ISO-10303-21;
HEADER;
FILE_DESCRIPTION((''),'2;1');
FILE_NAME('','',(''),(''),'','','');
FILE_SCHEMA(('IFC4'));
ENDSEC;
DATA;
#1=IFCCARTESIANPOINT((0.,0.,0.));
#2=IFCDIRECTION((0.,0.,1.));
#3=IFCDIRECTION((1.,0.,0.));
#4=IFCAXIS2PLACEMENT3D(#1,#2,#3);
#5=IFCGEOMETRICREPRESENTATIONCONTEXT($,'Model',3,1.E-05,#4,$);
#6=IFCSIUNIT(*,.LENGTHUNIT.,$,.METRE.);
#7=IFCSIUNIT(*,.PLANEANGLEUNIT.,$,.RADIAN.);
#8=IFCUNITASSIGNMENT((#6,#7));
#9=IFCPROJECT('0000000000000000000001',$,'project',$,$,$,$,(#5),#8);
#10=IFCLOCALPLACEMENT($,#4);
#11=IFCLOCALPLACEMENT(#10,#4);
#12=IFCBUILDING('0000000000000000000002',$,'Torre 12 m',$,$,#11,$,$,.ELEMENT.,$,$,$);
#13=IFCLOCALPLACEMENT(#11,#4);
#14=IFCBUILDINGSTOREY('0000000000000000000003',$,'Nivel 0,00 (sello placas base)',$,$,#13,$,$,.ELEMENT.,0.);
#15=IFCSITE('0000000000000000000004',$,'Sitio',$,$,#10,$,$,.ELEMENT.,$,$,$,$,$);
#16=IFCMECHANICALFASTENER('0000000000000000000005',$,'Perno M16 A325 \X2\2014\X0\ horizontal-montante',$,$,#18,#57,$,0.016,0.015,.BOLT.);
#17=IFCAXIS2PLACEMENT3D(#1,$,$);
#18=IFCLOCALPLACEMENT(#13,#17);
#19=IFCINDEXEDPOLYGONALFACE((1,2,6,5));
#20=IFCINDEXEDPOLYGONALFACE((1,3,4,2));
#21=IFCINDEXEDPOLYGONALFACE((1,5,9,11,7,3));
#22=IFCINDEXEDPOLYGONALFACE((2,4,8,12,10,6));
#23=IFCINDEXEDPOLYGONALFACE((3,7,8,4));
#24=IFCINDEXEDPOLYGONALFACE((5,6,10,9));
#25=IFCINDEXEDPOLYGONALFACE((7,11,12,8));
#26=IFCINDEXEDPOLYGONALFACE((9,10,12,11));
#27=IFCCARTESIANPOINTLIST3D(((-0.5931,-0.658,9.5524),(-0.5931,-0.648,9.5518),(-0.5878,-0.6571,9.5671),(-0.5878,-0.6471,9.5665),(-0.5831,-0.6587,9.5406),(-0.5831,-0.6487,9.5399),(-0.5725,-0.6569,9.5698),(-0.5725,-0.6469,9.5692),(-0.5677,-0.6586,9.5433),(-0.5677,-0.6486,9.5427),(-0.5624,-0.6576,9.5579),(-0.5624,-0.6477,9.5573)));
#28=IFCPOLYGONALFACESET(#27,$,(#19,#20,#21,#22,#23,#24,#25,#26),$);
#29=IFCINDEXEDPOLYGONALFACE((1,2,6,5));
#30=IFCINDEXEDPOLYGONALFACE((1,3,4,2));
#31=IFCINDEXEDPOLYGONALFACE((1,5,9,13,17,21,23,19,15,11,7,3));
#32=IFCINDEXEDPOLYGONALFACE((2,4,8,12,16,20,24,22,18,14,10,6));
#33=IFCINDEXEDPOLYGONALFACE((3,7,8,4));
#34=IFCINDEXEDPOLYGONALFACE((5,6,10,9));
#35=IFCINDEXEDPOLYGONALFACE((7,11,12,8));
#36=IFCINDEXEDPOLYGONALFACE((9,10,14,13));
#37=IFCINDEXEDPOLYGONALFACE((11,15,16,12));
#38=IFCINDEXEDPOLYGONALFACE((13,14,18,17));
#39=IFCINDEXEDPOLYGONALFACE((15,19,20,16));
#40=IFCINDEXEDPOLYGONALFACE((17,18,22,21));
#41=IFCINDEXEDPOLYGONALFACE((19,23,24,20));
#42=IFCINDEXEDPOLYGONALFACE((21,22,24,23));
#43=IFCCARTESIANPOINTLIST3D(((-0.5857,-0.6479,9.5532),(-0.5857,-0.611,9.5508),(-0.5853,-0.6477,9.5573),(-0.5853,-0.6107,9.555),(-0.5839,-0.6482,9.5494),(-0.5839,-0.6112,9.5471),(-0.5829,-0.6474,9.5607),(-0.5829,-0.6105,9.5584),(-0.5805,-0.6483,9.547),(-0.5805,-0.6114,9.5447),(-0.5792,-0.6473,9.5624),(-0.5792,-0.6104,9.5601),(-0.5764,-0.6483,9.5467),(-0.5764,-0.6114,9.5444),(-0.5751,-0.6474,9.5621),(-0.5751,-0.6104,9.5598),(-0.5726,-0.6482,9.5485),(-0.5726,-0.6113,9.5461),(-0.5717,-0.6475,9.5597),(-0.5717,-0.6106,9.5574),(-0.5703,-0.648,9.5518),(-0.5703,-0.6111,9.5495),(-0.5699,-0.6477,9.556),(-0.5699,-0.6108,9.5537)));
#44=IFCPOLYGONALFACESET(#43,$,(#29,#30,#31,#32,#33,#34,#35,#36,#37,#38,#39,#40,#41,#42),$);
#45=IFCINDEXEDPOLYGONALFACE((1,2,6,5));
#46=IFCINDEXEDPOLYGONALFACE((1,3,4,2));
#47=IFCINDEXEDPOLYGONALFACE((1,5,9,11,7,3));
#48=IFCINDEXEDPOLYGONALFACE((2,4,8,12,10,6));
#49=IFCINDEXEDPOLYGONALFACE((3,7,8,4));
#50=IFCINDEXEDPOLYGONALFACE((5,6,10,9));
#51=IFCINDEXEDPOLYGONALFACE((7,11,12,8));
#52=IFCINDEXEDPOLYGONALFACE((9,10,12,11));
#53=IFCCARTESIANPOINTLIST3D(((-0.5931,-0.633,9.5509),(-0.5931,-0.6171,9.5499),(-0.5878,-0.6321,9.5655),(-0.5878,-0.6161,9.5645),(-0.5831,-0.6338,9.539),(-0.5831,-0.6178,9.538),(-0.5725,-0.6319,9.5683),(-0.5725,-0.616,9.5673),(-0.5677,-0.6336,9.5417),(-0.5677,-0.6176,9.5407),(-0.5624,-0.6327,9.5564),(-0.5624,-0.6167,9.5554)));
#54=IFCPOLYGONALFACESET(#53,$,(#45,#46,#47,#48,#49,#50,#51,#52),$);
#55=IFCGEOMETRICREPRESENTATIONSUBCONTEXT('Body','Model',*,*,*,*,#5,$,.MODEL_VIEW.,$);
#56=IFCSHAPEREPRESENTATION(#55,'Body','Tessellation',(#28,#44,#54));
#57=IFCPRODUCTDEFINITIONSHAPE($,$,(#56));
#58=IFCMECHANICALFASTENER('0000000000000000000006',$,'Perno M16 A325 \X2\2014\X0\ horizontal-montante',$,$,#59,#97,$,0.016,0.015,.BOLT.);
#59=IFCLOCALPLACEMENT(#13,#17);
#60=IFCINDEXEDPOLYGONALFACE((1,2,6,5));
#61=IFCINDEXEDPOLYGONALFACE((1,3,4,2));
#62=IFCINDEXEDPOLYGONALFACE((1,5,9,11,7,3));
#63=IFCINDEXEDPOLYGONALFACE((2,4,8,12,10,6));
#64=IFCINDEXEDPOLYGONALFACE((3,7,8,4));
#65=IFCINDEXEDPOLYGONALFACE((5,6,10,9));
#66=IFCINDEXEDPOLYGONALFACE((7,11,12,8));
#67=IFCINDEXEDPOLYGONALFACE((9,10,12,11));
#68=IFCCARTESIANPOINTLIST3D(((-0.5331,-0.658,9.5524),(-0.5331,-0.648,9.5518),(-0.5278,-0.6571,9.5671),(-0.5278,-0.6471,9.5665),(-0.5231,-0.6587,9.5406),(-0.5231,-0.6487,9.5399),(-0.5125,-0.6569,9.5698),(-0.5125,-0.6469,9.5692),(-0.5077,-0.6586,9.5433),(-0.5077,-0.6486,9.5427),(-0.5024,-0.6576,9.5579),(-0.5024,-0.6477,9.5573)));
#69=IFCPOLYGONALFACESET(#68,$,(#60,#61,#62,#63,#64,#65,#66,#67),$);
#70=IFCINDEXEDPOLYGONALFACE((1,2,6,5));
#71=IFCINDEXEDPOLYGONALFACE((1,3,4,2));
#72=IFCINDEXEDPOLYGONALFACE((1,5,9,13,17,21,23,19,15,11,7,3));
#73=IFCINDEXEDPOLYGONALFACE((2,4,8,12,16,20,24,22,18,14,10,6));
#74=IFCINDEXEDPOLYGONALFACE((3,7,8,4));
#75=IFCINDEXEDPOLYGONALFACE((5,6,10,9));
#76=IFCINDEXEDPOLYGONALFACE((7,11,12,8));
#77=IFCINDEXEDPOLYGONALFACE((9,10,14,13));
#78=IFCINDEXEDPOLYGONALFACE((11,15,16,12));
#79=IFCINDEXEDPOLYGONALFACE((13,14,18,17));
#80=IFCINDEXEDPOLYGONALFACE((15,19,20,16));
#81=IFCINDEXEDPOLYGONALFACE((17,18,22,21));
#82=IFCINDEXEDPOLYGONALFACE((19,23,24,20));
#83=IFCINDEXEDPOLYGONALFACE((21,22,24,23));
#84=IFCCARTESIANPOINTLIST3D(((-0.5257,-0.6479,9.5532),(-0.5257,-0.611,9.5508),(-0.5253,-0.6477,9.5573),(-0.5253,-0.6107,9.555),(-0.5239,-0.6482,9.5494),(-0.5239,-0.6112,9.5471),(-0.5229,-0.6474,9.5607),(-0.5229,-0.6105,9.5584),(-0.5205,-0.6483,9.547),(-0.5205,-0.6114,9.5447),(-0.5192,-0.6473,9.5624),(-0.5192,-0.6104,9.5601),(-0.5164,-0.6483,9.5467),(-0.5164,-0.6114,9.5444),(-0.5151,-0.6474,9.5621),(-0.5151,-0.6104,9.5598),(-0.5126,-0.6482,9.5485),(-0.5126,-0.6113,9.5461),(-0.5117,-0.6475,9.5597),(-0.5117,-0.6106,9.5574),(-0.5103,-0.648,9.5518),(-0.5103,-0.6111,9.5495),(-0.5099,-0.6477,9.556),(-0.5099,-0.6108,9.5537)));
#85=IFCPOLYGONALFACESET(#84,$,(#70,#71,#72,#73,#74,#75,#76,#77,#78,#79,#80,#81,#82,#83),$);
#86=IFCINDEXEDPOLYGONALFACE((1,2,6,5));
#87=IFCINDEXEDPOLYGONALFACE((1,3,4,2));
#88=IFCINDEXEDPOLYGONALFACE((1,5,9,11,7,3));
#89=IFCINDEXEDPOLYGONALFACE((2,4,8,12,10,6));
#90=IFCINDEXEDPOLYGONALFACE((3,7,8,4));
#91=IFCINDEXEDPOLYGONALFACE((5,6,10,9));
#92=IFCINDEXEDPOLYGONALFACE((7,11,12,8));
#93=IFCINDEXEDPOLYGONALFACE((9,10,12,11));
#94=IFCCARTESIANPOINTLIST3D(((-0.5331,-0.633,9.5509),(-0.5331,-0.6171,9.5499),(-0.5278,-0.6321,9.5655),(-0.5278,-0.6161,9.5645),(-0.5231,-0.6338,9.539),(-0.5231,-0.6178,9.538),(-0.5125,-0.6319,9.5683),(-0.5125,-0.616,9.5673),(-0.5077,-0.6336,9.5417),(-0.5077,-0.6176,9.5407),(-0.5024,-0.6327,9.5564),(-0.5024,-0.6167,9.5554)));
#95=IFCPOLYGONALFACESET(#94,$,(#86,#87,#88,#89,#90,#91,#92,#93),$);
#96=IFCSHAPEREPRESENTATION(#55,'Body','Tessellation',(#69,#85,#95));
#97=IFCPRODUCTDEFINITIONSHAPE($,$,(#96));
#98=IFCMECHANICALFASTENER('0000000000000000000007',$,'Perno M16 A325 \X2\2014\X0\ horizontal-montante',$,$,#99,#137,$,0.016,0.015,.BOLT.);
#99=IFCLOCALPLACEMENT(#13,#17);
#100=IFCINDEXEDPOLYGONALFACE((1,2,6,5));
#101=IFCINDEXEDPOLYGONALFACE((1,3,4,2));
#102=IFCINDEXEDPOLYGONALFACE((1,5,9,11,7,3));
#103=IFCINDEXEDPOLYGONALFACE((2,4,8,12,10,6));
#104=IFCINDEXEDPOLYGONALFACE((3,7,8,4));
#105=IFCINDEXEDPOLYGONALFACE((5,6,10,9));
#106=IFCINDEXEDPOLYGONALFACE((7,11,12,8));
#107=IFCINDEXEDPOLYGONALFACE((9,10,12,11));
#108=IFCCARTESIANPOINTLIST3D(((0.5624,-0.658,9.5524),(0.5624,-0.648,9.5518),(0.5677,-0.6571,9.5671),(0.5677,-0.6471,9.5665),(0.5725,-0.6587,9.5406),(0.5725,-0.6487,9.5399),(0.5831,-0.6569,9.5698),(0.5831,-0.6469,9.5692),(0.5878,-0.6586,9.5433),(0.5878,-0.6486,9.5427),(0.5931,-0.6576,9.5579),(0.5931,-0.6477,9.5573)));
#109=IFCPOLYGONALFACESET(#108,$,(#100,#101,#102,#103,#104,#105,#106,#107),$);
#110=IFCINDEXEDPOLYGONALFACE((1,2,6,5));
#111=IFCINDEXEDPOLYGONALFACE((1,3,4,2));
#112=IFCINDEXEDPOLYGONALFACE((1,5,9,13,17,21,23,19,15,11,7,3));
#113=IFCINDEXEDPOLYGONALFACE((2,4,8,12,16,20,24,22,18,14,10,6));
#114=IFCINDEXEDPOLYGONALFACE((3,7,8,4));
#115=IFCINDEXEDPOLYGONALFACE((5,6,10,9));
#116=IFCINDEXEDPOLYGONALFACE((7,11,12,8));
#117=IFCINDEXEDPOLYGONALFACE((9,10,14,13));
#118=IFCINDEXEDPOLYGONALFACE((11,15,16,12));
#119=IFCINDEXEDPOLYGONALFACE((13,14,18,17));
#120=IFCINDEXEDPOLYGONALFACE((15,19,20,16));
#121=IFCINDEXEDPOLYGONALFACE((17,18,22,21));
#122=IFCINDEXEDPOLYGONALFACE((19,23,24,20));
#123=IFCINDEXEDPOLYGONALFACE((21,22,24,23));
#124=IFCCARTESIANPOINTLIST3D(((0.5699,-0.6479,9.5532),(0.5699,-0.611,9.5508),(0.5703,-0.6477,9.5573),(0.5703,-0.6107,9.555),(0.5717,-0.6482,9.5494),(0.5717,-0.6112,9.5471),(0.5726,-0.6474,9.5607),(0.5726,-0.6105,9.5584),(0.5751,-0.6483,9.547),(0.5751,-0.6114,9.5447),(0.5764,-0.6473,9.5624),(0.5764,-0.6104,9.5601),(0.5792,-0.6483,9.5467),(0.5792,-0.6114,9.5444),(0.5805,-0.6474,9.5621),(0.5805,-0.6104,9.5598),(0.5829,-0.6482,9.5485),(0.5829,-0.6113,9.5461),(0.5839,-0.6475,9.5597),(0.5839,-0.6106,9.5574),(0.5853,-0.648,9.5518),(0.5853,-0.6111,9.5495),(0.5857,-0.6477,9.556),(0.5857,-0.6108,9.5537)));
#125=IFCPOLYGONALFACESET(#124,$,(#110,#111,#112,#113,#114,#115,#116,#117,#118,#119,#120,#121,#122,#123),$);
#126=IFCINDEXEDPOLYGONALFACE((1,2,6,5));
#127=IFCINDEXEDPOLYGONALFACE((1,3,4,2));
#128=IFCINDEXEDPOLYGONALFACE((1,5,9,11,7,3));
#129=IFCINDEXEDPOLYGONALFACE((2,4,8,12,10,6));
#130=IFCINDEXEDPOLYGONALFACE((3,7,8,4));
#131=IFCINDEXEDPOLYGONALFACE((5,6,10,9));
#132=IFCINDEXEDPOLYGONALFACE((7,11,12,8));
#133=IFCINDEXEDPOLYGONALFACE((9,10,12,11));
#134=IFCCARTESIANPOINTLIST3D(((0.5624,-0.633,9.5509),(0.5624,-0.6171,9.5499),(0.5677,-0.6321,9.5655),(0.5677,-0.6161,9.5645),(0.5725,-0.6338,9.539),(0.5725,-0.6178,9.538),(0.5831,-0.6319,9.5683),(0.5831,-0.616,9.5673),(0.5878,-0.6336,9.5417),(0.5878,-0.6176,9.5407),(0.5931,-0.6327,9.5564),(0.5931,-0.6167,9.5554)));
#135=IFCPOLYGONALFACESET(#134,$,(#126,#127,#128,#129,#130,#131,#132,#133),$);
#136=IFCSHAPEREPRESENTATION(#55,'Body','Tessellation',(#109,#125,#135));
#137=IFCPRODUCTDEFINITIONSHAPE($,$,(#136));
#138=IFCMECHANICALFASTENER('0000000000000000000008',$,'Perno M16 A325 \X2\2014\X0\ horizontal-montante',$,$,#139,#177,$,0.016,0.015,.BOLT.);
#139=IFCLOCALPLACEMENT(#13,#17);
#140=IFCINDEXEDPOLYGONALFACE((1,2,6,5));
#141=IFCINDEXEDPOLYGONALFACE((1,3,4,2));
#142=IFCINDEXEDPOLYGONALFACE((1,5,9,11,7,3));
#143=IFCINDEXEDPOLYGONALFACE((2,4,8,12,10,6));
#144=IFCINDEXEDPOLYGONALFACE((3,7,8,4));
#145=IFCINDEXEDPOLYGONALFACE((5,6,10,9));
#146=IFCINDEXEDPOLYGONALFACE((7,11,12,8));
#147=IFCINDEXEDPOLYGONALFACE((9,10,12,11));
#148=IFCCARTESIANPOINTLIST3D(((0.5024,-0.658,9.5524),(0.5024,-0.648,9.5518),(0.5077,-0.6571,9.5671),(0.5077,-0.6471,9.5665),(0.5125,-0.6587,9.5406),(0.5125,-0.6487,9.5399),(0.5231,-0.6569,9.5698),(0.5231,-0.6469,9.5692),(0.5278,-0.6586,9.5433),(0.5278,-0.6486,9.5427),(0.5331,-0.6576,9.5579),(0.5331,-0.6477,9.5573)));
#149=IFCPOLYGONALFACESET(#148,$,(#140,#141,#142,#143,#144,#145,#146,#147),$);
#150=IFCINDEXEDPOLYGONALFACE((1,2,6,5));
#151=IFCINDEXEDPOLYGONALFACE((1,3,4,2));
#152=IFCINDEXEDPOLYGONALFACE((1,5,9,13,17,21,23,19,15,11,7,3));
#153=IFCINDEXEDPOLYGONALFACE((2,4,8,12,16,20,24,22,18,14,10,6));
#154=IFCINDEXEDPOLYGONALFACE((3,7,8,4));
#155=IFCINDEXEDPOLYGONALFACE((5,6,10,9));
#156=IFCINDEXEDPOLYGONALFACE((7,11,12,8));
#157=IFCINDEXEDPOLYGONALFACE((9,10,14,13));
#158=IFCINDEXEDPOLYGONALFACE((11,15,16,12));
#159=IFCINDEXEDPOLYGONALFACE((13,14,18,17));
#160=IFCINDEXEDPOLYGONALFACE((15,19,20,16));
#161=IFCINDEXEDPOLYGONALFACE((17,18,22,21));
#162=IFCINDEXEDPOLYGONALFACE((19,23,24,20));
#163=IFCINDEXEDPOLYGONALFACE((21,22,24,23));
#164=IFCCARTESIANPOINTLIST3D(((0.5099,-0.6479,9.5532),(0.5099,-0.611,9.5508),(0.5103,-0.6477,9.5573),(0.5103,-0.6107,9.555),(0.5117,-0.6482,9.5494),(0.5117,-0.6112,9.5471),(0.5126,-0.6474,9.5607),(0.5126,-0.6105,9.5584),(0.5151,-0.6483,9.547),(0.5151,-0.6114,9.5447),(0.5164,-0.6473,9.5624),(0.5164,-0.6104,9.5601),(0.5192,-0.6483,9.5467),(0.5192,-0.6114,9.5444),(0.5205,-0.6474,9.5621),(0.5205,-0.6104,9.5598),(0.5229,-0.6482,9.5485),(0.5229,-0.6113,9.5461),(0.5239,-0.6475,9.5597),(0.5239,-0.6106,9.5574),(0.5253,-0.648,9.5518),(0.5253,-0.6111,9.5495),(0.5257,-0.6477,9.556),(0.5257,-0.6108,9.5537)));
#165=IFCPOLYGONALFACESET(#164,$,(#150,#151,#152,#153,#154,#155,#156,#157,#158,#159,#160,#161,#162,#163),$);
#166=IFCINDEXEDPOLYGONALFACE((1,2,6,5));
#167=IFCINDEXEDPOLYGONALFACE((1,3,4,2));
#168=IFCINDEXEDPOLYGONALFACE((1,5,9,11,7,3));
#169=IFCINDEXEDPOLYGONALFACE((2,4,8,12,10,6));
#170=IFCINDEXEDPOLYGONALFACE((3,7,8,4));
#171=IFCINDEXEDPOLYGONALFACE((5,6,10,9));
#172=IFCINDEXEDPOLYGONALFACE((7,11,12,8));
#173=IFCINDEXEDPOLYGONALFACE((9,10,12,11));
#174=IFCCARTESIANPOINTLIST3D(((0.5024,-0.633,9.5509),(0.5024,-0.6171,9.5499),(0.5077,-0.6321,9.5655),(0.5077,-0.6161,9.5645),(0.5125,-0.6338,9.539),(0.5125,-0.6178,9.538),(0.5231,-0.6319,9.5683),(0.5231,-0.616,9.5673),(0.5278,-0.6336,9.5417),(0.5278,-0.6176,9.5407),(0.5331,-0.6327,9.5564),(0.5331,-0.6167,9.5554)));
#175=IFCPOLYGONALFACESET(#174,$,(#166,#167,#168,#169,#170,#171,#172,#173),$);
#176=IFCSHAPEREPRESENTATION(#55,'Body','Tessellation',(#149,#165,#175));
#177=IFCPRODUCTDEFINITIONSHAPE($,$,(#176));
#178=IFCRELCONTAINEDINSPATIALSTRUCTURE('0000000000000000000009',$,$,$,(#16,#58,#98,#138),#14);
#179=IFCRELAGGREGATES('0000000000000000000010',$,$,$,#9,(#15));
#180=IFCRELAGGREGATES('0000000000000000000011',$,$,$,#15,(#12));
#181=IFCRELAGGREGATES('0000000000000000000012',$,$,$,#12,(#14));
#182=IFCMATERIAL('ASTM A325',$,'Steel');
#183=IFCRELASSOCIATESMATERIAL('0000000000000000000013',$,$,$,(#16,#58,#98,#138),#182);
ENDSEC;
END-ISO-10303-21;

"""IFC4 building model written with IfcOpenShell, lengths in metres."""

from ifc_helpers import new_model, si_unit, frame, origin_with_axes, place, context, subcontext, project, spatial, polyline, outline, extrude, material, element, save


model = new_model("IFC4")

# Units and contexts
model_context = context("Model", 3, precision=1e-05, world=origin_with_axes())
body_context = subcontext(model_context, "Body", "Model", "MODEL_VIEW")
ifc_project = project(units=[si_unit("LENGTHUNIT", "METRE"), si_unit("PLANEANGLEUNIT", "RADIAN")], contexts=[model_context])

# Site, building, storey
site_placement = place(None, origin_with_axes())
site = spatial("IfcSite", under=ifc_project, at=site_placement, Name="Sitio", CompositionType="ELEMENT")
building_placement = place(site_placement, origin_with_axes())
building = spatial("IfcBuilding", under=site, at=building_placement, Name="Torre 12 m", CompositionType="ELEMENT")
storey_placement = place(building_placement, origin_with_axes())
storey = spatial("IfcBuildingStorey", under=building, at=storey_placement, Name="Nivel 0,00 (sello placas base)", CompositionType="ELEMENT", Elevation=0.0)

# Shared definitions
placement = place(storey_placement, origin_with_axes())

# Mechanical fasteners
ifc_material_1 = material(Name="ASTM A325", Category="Steel")
element("IfcMechanicalFastener", 1, at=placement, inside=storey, material=ifc_material_1, Name="Perno M16 A325 — horizontal-montante", NominalDiameter=0.016, NominalLength=0.015, PredefinedType="BOLT", context=body_context, shape_type="SweptSolid", body=[
    extrude(outline(polyline([(0.0135, 0.0078), (0.0, 0.0156), (-0.0135, 0.0078), (-0.0135, -0.0078), (0.0, -0.0156), (0.0135, -0.0078), (0.0135, 0.0078)])), frame((-0.5778, -0.6578, 9.5552), z_axis=(0.0, 0.998053, -0.062378), x_axis=(0.940405, -0.021212, -0.339394)), (0.0, 0.0, 1.0), 0.01),
    extrude(outline(polyline([(0.008, 0.0), (0.0069, 0.004), (0.004, 0.0069), (0.0, 0.008), (-0.004, 0.0069), (-0.0069, 0.004), (-0.008, 0.0), (-0.0069, -0.004), (-0.004, -0.0069), (0.0, -0.008), (0.004, -0.0069), (0.0069, -0.004), (0.008, 0.0)])), frame((-0.5778, -0.6478, 9.5546), z_axis=(0.0, 0.998053, -0.062378), x_axis=(0.940405, -0.021212, -0.339394)), (0.0, 0.0, 1.0), 0.037),
    extrude(outline(polyline([(0.0135, 0.0078), (0.0, 0.0156), (-0.0135, 0.0078), (-0.0135, -0.0078), (0.0, -0.0156), (0.0135, -0.0078), (0.0135, 0.0078)])), frame((-0.5778, -0.6329, 9.5536), z_axis=(0.0, 0.998053, -0.062378), x_axis=(0.940405, -0.021212, -0.339394)), (0.0, 0.0, 1.0), 0.016),
])
element("IfcMechanicalFastener", 2, at=placement, inside=storey, material=ifc_material_1, Name="Perno M16 A325 — horizontal-montante", NominalDiameter=0.016, NominalLength=0.015, PredefinedType="BOLT", context=body_context, shape_type="SweptSolid", body=[
    extrude(outline(polyline([(0.0135, 0.0078), (0.0, 0.0156), (-0.0135, 0.0078), (-0.0135, -0.0078), (0.0, -0.0156), (0.0135, -0.0078), (0.0135, 0.0078)])), frame((-0.5178, -0.6578, 9.5552), z_axis=(0.0, 0.998053, -0.062378), x_axis=(0.940405, -0.021212, -0.339394)), (0.0, 0.0, 1.0), 0.01),
    extrude(outline(polyline([(0.008, 0.0), (0.0069, 0.004), (0.004, 0.0069), (0.0, 0.008), (-0.004, 0.0069), (-0.0069, 0.004), (-0.008, 0.0), (-0.0069, -0.004), (-0.004, -0.0069), (0.0, -0.008), (0.004, -0.0069), (0.0069, -0.004), (0.008, 0.0)])), frame((-0.5178, -0.6478, 9.5546), z_axis=(0.0, 0.998053, -0.062378), x_axis=(0.940405, -0.021212, -0.339394)), (0.0, 0.0, 1.0), 0.037),
    extrude(outline(polyline([(0.0135, 0.0078), (0.0, 0.0156), (-0.0135, 0.0078), (-0.0135, -0.0078), (0.0, -0.0156), (0.0135, -0.0078), (0.0135, 0.0078)])), frame((-0.5178, -0.6329, 9.5536), z_axis=(0.0, 0.998053, -0.062378), x_axis=(0.940405, -0.021212, -0.339394)), (0.0, 0.0, 1.0), 0.016),
])
element("IfcMechanicalFastener", 3, at=placement, inside=storey, material=ifc_material_1, Name="Perno M16 A325 — horizontal-montante", NominalDiameter=0.016, NominalLength=0.015, PredefinedType="BOLT", context=body_context, shape_type="SweptSolid", body=[
    extrude(outline(polyline([(0.0135, 0.0078), (0.0, 0.0156), (-0.0135, 0.0078), (-0.0135, -0.0078), (0.0, -0.0156), (0.0135, -0.0078), (0.0135, 0.0078)])), frame((0.5778, -0.6578, 9.5552), z_axis=(0.0, 0.998053, -0.062378), x_axis=(0.940405, -0.021212, -0.339394)), (0.0, 0.0, 1.0), 0.01),
    extrude(outline(polyline([(0.008, 0.0), (0.0069, 0.004), (0.004, 0.0069), (0.0, 0.008), (-0.004, 0.0069), (-0.0069, 0.004), (-0.008, 0.0), (-0.0069, -0.004), (-0.004, -0.0069), (0.0, -0.008), (0.004, -0.0069), (0.0069, -0.004), (0.008, 0.0)])), frame((0.5778, -0.6478, 9.5546), z_axis=(0.0, 0.998053, -0.062378), x_axis=(0.940405, -0.021212, -0.339394)), (0.0, 0.0, 1.0), 0.037),
    extrude(outline(polyline([(0.0135, 0.0078), (0.0, 0.0156), (-0.0135, 0.0078), (-0.0135, -0.0078), (0.0, -0.0156), (0.0135, -0.0078), (0.0135, 0.0078)])), frame((0.5778, -0.6329, 9.5536), z_axis=(0.0, 0.998053, -0.062378), x_axis=(0.940405, -0.021212, -0.339394)), (0.0, 0.0, 1.0), 0.016),
])
element("IfcMechanicalFastener", 4, at=placement, inside=storey, material=ifc_material_1, Name="Perno M16 A325 — horizontal-montante", NominalDiameter=0.016, NominalLength=0.015, PredefinedType="BOLT", context=body_context, shape_type="SweptSolid", body=[
    extrude(outline(polyline([(0.0135, 0.0078), (0.0, 0.0156), (-0.0135, 0.0078), (-0.0135, -0.0078), (0.0, -0.0156), (0.0135, -0.0078), (0.0135, 0.0078)])), frame((0.5178, -0.6578, 9.5552), z_axis=(0.0, 0.998053, -0.062378), x_axis=(0.940405, -0.021212, -0.339394)), (0.0, 0.0, 1.0), 0.01),
    extrude(outline(polyline([(0.008, 0.0), (0.0069, 0.004), (0.004, 0.0069), (0.0, 0.008), (-0.004, 0.0069), (-0.0069, 0.004), (-0.008, 0.0), (-0.0069, -0.004), (-0.004, -0.0069), (0.0, -0.008), (0.004, -0.0069), (0.0069, -0.004), (0.008, 0.0)])), frame((0.5178, -0.6478, 9.5546), z_axis=(0.0, 0.998053, -0.062378), x_axis=(0.940405, -0.021212, -0.339394)), (0.0, 0.0, 1.0), 0.037),
    extrude(outline(polyline([(0.0135, 0.0078), (0.0, 0.0156), (-0.0135, 0.0078), (-0.0135, -0.0078), (0.0, -0.0156), (0.0135, -0.0078), (0.0135, 0.0078)])), frame((0.5178, -0.6329, 9.5536), z_axis=(0.0, 0.998053, -0.062378), x_axis=(0.940405, -0.021212, -0.339394)), (0.0, 0.0, 1.0), 0.016),
])

save(model, "model.ifc")
